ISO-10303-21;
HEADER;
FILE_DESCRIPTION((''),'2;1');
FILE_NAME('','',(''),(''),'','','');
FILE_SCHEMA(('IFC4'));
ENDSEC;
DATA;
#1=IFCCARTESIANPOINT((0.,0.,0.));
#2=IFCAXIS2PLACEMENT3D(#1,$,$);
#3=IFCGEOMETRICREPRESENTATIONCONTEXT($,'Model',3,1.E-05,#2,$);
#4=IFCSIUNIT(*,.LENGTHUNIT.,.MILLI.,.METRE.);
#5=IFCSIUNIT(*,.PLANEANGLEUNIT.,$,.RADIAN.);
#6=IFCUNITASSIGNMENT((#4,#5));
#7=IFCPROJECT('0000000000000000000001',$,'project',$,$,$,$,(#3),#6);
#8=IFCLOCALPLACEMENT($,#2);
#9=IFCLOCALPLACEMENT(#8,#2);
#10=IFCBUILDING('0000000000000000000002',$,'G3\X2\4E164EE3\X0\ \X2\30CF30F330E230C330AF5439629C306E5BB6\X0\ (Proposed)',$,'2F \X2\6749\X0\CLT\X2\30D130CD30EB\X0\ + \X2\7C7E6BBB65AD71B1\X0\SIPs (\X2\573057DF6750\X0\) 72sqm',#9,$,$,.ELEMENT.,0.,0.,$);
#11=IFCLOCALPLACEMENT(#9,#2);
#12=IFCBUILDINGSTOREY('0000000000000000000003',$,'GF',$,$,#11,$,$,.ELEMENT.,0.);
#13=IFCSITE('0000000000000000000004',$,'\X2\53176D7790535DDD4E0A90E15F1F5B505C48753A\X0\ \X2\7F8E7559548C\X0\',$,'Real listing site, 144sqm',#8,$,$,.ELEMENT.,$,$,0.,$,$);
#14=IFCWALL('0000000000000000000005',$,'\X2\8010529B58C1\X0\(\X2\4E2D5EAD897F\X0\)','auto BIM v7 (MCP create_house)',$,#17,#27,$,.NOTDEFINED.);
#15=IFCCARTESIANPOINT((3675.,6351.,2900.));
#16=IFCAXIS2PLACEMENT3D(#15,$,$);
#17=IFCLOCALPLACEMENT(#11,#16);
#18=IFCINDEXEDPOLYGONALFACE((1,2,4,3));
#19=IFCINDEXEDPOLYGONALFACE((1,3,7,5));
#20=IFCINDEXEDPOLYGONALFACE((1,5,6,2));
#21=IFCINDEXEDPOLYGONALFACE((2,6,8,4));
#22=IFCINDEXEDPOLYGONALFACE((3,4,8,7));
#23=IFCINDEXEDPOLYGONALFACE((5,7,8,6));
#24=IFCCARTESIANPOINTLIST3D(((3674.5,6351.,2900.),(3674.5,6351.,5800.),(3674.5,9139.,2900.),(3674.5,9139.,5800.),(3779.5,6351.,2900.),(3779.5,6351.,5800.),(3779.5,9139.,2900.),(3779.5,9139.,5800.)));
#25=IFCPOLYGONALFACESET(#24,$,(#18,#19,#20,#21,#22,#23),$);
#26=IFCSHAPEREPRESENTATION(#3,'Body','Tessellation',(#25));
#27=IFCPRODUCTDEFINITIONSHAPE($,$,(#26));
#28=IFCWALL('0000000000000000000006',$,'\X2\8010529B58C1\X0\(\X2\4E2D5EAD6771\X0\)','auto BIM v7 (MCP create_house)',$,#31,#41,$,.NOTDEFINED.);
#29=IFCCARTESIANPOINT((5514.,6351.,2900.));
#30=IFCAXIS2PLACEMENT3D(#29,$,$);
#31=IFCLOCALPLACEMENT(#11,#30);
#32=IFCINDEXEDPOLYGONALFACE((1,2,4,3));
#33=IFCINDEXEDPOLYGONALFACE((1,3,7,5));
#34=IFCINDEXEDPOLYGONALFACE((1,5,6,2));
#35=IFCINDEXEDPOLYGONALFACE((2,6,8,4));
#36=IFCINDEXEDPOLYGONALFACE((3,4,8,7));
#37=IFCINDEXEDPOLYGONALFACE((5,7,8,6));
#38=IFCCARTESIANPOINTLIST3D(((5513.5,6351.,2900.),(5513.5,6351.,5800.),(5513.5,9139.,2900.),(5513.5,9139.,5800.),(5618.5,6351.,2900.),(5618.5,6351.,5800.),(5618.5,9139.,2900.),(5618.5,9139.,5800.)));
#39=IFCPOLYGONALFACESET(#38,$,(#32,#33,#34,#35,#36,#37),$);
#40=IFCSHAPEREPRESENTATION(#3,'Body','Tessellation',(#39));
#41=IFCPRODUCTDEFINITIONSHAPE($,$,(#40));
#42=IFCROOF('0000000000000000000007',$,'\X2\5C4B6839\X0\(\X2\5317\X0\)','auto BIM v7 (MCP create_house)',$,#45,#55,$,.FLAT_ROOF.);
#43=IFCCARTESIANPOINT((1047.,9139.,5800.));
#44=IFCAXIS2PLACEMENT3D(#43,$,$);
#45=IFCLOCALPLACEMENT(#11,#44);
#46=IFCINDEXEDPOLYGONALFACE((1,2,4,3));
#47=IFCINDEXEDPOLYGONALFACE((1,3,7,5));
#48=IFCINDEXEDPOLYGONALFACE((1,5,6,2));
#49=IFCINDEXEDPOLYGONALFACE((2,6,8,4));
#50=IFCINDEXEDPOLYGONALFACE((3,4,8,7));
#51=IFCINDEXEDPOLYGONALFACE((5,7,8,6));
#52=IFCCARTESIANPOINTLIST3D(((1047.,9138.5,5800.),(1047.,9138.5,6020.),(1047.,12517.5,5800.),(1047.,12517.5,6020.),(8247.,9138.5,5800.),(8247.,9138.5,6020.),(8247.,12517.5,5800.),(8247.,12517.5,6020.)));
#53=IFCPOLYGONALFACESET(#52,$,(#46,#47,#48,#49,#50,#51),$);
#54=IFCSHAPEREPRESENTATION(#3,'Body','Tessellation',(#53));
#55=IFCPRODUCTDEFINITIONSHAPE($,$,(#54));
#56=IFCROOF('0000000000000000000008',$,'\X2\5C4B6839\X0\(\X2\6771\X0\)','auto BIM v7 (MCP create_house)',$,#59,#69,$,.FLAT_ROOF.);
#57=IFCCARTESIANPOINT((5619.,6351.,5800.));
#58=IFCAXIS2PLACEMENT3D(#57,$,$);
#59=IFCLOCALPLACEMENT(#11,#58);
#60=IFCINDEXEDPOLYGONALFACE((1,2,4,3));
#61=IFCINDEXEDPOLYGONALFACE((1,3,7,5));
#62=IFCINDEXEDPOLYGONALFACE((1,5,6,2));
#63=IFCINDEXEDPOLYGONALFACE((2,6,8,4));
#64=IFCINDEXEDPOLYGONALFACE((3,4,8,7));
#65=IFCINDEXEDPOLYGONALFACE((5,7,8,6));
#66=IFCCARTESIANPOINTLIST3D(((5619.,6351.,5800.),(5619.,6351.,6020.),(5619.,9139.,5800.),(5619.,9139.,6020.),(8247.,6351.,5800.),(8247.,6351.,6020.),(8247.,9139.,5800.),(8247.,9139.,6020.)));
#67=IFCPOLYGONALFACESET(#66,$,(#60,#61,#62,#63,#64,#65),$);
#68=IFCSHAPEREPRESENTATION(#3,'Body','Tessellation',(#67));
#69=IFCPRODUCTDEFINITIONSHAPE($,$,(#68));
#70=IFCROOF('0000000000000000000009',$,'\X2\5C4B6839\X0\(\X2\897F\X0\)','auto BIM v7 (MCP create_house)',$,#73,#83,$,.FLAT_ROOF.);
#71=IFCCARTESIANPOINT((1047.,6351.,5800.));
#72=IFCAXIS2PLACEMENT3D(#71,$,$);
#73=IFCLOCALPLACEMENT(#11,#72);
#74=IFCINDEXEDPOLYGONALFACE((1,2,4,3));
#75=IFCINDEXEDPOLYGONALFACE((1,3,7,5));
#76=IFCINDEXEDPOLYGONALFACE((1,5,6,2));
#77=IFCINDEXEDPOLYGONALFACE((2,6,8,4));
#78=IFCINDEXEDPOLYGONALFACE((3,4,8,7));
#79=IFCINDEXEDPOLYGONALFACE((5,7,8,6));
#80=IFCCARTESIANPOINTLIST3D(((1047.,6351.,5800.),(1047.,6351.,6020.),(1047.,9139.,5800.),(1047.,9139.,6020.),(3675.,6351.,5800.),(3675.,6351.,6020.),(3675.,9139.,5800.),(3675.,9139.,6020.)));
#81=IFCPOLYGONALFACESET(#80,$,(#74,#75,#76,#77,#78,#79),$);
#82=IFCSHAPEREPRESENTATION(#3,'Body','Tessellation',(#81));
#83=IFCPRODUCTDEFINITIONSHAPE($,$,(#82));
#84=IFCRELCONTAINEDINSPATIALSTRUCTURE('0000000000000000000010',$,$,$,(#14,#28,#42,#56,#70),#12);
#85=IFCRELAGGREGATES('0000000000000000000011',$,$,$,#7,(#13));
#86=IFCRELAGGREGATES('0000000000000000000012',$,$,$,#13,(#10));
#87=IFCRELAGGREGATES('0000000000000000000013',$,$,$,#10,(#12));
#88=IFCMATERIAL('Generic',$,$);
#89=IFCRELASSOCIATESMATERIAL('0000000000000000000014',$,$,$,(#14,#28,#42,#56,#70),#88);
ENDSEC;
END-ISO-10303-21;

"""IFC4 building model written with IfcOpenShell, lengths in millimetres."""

from ifc_helpers import new_model, si_unit, frame, frame_2d, origin, place, context, project, spatial, rectangle, extrude, material, element, save


model = new_model("IFC4")

# Units and contexts
model_context = context("Model", 3, precision=1e-05, world=origin())
ifc_project = project(units=[si_unit("LENGTHUNIT", "METRE", prefix="MILLI"), si_unit("PLANEANGLEUNIT", "RADIAN")], contexts=[model_context])

# Site, building, storey
site_placement = place(None, origin())
site = spatial("IfcSite", under=ifc_project, at=site_placement, Name="北海道川上郡弟子屈町 美留和", ObjectType="Real listing site, 144sqm", CompositionType="ELEMENT", RefElevation=0.0)
building_placement = place(site_placement, origin())
building = spatial("IfcBuilding", under=site, at=building_placement, Name="G3世代 ハンモック吹抜の家 (Proposed)", ObjectType="2F 杉CLTパネル + 籾殻断熱SIPs (地域材) 72sqm", CompositionType="ELEMENT", ElevationOfRefHeight=0.0, ElevationOfTerrain=0.0)
storey_placement = place(building_placement, origin())
storey = spatial("IfcBuildingStorey", under=building, at=storey_placement, Name="GF", CompositionType="ELEMENT", Elevation=0.0)

# Shared definitions
ifc_material = material(Name="Generic")

# Walls
wall_1_placement = place(storey_placement, frame((3675.0, 6351.0, 2900.0)))
element("IfcWall", 1, at=wall_1_placement, inside=storey, material=ifc_material, Name="耐力壁(中庭西)", Description="auto BIM v7 (MCP create_house)", PredefinedType="NOTDEFINED", context=model_context, shape_type="SweptSolid", body=[
    extrude(rectangle(XDim=105.0, YDim=2788.0, at=frame_2d((52.0, 1394.0))), frame((3675.0, 6351.0, 2900.0)), (0.0, 0.0, 1.0), 2900.0),
])
wall_2_placement = place(storey_placement, frame((5514.0, 6351.0, 2900.0)))
element("IfcWall", 2, at=wall_2_placement, inside=storey, material=ifc_material, Name="耐力壁(中庭東)", Description="auto BIM v7 (MCP create_house)", PredefinedType="NOTDEFINED", context=model_context, shape_type="SweptSolid", body=[
    extrude(rectangle(XDim=105.0, YDim=2788.0, at=frame_2d((52.0, 1394.0))), frame((5514.0, 6351.0, 2900.0)), (0.0, 0.0, 1.0), 2900.0),
])

# Roofs
roof_1_placement = place(storey_placement, frame((1047.0, 9139.0, 5800.0)))
element("IfcRoof", 3, at=roof_1_placement, inside=storey, material=ifc_material, Name="屋根(北)", Description="auto BIM v7 (MCP create_house)", PredefinedType="FLAT_ROOF", context=model_context, shape_type="SweptSolid", body=[
    extrude(rectangle(XDim=7200.0, YDim=3379.0, at=frame_2d((3600.0, 1689.0))), frame((1047.0, 9139.0, 5800.0)), (0.0, 0.0, 1.0), 220.0),
])
roof_2_placement = place(storey_placement, frame((5619.0, 6351.0, 5800.0)))
element("IfcRoof", 4, at=roof_2_placement, inside=storey, material=ifc_material, Name="屋根(東)", Description="auto BIM v7 (MCP create_house)", PredefinedType="FLAT_ROOF", context=model_context, shape_type="SweptSolid", body=[
    extrude(rectangle(XDim=2628.0, YDim=2788.0, at=frame_2d((1314.0, 1394.0))), frame((5619.0, 6351.0, 5800.0)), (0.0, 0.0, 1.0), 220.0),
])
roof_3_placement = place(storey_placement, frame((1047.0, 6351.0, 5800.0)))
element("IfcRoof", 5, at=roof_3_placement, inside=storey, material=ifc_material, Name="屋根(西)", Description="auto BIM v7 (MCP create_house)", PredefinedType="FLAT_ROOF", context=model_context, shape_type="SweptSolid", body=[
    extrude(rectangle(XDim=2628.0, YDim=2788.0, at=frame_2d((1314.0, 1394.0))), frame((1047.0, 6351.0, 5800.0)), (0.0, 0.0, 1.0), 220.0),
])

save(model, "model.ifc")
